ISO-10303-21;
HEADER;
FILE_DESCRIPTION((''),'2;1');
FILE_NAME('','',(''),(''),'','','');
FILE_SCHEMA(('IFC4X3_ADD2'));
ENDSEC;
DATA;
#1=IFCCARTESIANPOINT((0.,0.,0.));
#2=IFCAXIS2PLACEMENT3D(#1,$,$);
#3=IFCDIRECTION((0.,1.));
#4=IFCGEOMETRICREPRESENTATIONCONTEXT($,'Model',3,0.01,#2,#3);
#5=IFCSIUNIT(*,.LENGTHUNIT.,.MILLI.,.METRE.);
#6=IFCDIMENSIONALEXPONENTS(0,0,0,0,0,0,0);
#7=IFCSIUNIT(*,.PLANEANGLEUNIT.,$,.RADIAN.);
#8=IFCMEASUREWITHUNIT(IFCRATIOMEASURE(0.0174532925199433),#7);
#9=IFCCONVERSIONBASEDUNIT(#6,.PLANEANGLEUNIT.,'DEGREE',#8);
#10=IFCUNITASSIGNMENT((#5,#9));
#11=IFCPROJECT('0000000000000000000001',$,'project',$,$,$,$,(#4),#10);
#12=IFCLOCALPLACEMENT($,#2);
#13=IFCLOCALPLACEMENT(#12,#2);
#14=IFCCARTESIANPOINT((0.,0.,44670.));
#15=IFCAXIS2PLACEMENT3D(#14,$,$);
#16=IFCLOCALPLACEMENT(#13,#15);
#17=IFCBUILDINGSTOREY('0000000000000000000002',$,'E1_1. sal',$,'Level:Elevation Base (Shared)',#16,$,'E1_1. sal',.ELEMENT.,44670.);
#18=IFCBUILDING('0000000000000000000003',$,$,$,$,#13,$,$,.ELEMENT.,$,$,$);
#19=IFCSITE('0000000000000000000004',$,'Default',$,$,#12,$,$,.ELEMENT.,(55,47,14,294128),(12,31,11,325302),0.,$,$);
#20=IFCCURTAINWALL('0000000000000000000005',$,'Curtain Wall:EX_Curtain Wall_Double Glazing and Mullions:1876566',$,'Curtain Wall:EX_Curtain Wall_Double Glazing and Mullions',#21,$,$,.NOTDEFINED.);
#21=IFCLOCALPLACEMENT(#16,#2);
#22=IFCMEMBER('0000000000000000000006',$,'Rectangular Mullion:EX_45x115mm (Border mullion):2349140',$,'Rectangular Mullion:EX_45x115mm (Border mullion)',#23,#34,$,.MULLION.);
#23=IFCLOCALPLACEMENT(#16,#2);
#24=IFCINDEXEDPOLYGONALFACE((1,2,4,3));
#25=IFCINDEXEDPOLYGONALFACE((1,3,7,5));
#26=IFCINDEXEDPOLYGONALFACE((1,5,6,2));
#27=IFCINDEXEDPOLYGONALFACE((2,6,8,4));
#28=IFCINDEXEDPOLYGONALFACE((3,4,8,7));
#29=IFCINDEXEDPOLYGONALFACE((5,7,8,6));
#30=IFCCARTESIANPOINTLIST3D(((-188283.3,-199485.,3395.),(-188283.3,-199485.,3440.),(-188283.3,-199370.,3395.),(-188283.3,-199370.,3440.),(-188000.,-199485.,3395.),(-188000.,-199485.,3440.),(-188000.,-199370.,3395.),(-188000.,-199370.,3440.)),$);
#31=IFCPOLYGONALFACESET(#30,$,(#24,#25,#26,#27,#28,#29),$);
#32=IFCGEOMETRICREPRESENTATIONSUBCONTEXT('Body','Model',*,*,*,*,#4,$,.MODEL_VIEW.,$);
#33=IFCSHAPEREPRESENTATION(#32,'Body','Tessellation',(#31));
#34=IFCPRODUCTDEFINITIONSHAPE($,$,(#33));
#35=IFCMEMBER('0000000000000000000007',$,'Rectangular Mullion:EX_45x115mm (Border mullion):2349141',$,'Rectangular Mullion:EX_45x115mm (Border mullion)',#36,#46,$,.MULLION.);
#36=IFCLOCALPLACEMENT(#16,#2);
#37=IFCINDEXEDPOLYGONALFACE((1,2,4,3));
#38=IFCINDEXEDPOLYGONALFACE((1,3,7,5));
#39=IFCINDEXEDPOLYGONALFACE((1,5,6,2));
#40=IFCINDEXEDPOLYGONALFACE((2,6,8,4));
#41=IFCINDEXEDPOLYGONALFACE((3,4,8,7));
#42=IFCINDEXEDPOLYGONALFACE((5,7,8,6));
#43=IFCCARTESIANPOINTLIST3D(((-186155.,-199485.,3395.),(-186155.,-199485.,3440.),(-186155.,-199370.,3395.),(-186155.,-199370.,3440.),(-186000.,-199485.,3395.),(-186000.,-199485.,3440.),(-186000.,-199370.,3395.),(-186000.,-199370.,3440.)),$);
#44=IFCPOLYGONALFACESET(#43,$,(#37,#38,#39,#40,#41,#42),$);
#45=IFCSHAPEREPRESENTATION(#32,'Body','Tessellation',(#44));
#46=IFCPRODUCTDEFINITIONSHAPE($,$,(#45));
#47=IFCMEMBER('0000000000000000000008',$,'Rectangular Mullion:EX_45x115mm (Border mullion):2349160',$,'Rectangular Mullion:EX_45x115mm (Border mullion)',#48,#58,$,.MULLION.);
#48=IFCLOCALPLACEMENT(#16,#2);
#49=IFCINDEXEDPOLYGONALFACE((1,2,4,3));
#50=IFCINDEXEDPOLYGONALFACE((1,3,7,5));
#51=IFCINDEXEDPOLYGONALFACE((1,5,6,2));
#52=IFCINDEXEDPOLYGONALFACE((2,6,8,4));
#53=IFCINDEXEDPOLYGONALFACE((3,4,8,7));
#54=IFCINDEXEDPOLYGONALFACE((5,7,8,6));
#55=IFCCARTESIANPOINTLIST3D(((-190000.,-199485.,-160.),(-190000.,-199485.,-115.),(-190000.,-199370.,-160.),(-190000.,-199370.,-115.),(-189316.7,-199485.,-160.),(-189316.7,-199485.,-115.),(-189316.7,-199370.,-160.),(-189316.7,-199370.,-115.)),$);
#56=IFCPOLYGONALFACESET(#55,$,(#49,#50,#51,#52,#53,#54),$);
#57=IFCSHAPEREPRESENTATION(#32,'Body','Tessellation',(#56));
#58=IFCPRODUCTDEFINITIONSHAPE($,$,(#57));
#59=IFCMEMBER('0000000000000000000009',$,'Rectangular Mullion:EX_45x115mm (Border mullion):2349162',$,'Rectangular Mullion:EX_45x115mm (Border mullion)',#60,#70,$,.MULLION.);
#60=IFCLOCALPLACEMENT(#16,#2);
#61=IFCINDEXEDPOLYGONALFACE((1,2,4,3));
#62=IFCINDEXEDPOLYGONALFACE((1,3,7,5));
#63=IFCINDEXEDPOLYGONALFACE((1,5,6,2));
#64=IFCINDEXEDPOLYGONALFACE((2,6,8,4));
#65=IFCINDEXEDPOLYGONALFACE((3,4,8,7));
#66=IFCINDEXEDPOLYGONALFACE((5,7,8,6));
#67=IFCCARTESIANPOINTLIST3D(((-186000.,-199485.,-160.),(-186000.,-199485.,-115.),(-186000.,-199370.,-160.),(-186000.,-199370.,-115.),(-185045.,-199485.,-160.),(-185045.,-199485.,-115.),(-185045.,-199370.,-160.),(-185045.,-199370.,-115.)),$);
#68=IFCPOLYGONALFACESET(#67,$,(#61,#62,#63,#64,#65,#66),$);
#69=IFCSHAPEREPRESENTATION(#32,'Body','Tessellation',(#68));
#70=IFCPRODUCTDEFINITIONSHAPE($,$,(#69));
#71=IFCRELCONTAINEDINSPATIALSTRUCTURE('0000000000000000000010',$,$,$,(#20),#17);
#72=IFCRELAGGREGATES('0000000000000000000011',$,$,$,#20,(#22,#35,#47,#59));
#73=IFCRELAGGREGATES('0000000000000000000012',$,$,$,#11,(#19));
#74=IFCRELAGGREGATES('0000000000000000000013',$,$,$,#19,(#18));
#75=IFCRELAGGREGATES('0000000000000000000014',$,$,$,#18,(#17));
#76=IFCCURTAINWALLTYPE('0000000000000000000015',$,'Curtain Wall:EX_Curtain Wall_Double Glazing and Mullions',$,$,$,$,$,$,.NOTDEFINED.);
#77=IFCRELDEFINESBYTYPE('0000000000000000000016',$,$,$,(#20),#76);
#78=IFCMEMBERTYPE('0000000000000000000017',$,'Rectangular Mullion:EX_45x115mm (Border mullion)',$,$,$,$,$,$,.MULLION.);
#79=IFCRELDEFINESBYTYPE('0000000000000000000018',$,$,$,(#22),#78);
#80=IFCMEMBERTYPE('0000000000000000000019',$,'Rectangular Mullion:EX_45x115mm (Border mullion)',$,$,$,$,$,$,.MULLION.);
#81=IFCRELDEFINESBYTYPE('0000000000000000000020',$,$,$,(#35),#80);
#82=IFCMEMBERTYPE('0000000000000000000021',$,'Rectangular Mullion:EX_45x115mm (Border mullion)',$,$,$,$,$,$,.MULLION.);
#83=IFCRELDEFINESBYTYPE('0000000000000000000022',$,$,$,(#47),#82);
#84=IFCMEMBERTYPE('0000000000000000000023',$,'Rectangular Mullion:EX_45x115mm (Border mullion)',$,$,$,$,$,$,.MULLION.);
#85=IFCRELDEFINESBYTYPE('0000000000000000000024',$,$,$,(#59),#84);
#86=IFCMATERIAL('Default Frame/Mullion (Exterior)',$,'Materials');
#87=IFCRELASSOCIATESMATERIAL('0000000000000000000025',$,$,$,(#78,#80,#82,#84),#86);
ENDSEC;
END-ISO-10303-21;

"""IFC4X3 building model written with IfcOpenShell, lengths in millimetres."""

from ifc_helpers import new_model, entity, si_unit, converted_unit, direction, frame, origin, origin_2d_with_axis, place, context, subcontext, project, spatial, rectangle, extrude, source, transform, mapped, material, material_profile, profile_set, type_object, type_shapes, element, aggregate, save


model = new_model("IFC4X3")

# Units and contexts
model_context = context("Model", 3, precision=0.01, world=origin(), true_north=direction((0.0, 1.0)))
body_context = subcontext(model_context, "Body", "Model", "MODEL_VIEW")
ifc_project = project(units=[si_unit("LENGTHUNIT", "METRE", prefix="MILLI"), converted_unit("PLANEANGLEUNIT", "DEGREE", entity("IfcRatioMeasure", 0.0174532925199433), si_unit("PLANEANGLEUNIT", "RADIAN"), dimensions=[0, 0, 0, 0, 0, 0, 0])], contexts=[model_context])

# Site, building, storey
site_placement = place(None, origin())
site = spatial("IfcSite", under=ifc_project, at=site_placement, Name="Default", CompositionType="ELEMENT", RefLatitude=(55, 47, 14, 294128), RefLongitude=(12, 31, 11, 325302), RefElevation=0.0)
building_placement = place(site_placement, origin())
building = spatial("IfcBuilding", under=site, at=building_placement, CompositionType="ELEMENT")
storey_placement = place(building_placement, frame((0.0, 0.0, 44670.0)))
storey = spatial("IfcBuildingStorey", under=building, at=storey_placement, Name="E1_1. sal", ObjectType="Level:Elevation Base (Shared)", LongName="E1_1. sal", CompositionType="ELEMENT", Elevation=44670.0)

# Curtain wall, members
curtain_wall_type = type_object("IfcCurtainWallType", Name="Curtain Wall:EX_Curtain Wall_Double Glazing and Mullions", PredefinedType="NOTDEFINED")
curtain_wall_placement = place(storey_placement, frame((0.0, 0.0, -44670.0)))
curtain_wall = element("IfcCurtainWall", 1, at=curtain_wall_placement, inside=storey, type_object=curtain_wall_type, Name="Curtain Wall:EX_Curtain Wall_Double Glazing and Mullions:1876566", ObjectType="Curtain Wall:EX_Curtain Wall_Double Glazing and Mullions", PredefinedType="NOTDEFINED")
ifc_material_1 = material(Name="Default Frame/Mullion (Exterior)", Category="Materials")
ifc_material_profile_1 = material_profile(ifc_material_1, rectangle(XDim=115.0, YDim=45.0, at=origin_2d_with_axis()), Name="EX_45x115mm (Border mullion)")
ifc_profile_set_1 = profile_set([ifc_material_profile_1], Name="EX_45x115mm (Border mullion)")
member_type_1 = type_object("IfcMemberType", Name="Rectangular Mullion:EX_45x115mm (Border mullion)", PredefinedType="MULLION", material=ifc_profile_set_1)
shared_shape_1 = source(origin(), body_context, "Body", "SweptSolid", [
    extrude(rectangle(XDim=115.0, YDim=45.0, at=origin_2d_with_axis()), frame((-22.5, -57.5, -283.3), z_axis=(0.0, 0.0, 1.0), x_axis=(0.0, -1.0, 0.0)), (0.0, 0.0, 1.0), 283.3),
])
type_shapes(member_type_1, [shared_shape_1])
member_1_placement = place(curtain_wall_placement, frame((-188000.0, -199485.0, 48110.0), z_axis=(1.0, 0.0, 0.0), x_axis=(0.0, 0.0, 1.0)))
member_1 = element("IfcMember", 2, at=member_1_placement, type_object=member_type_1, Name="Rectangular Mullion:EX_45x115mm (Border mullion):2349140", ObjectType="Rectangular Mullion:EX_45x115mm (Border mullion)", PredefinedType="MULLION", context=body_context, shape_type="MappedRepresentation", body=[
    mapped(shared_shape_1, transform((0.0, 0.0, 0.0), scale=1.0)),
])
member_type_2 = type_object("IfcMemberType", Name="Rectangular Mullion:EX_45x115mm (Border mullion)", PredefinedType="MULLION", material=ifc_profile_set_1)
shared_shape_2 = source(origin(), body_context, "Body", "SweptSolid", [
    extrude(rectangle(XDim=115.0, YDim=45.0, at=origin_2d_with_axis()), frame((-22.5, -57.5, -155.0), z_axis=(0.0, 0.0, 1.0), x_axis=(0.0, -1.0, 0.0)), (0.0, 0.0, 1.0), 155.0),
])
type_shapes(member_type_2, [shared_shape_2])
member_2_placement = place(curtain_wall_placement, frame((-186000.0, -199485.0, 48110.0), z_axis=(1.0, 0.0, 0.0), x_axis=(0.0, 0.0, 1.0)))
member_2 = element("IfcMember", 3, at=member_2_placement, type_object=member_type_2, Name="Rectangular Mullion:EX_45x115mm (Border mullion):2349141", ObjectType="Rectangular Mullion:EX_45x115mm (Border mullion)", PredefinedType="MULLION", context=body_context, shape_type="MappedRepresentation", body=[
    mapped(shared_shape_2, transform((0.0, 0.0, 0.0), scale=1.0)),
])
member_type_3 = type_object("IfcMemberType", Name="Rectangular Mullion:EX_45x115mm (Border mullion)", PredefinedType="MULLION", material=ifc_profile_set_1)
shared_shape_3 = source(origin(), body_context, "Body", "SweptSolid", [
    extrude(rectangle(XDim=115.0, YDim=45.0, at=origin_2d_with_axis()), frame((-22.5, -57.5, -683.3), z_axis=(0.0, 0.0, 1.0), x_axis=(0.0, -1.0, 0.0)), (0.0, 0.0, 1.0), 683.3),
])
type_shapes(member_type_3, [shared_shape_3])
member_3_placement = place(curtain_wall_placement, frame((-190000.0, -199485.0, 44510.0), z_axis=(-1.0, 0.0, 0.0), x_axis=(0.0, 0.0, -1.0)))
member_3 = element("IfcMember", 4, at=member_3_placement, type_object=member_type_3, Name="Rectangular Mullion:EX_45x115mm (Border mullion):2349160", ObjectType="Rectangular Mullion:EX_45x115mm (Border mullion)", PredefinedType="MULLION", context=body_context, shape_type="MappedRepresentation", body=[
    mapped(shared_shape_3, transform((0.0, 0.0, 0.0), scale=1.0)),
])
member_type_4 = type_object("IfcMemberType", Name="Rectangular Mullion:EX_45x115mm (Border mullion)", PredefinedType="MULLION", material=ifc_profile_set_1)
shared_shape_4 = source(origin(), body_context, "Body", "SweptSolid", [
    extrude(rectangle(XDim=115.0, YDim=45.0, at=origin_2d_with_axis()), frame((-22.5, -57.5, -955.0), z_axis=(0.0, 0.0, 1.0), x_axis=(0.0, -1.0, 0.0)), (0.0, 0.0, 1.0), 955.0),
])
type_shapes(member_type_4, [shared_shape_4])
member_4_placement = place(curtain_wall_placement, frame((-186000.0, -199485.0, 44510.0), z_axis=(-1.0, 0.0, 0.0), x_axis=(0.0, 0.0, -1.0)))
member_4 = element("IfcMember", 5, at=member_4_placement, type_object=member_type_4, Name="Rectangular Mullion:EX_45x115mm (Border mullion):2349162", ObjectType="Rectangular Mullion:EX_45x115mm (Border mullion)", PredefinedType="MULLION", context=body_context, shape_type="MappedRepresentation", body=[
    mapped(shared_shape_4, transform((0.0, 0.0, 0.0), scale=1.0)),
])
aggregate(curtain_wall, [member_1, member_2, member_3, member_4])

save(model, "model.ifc")
